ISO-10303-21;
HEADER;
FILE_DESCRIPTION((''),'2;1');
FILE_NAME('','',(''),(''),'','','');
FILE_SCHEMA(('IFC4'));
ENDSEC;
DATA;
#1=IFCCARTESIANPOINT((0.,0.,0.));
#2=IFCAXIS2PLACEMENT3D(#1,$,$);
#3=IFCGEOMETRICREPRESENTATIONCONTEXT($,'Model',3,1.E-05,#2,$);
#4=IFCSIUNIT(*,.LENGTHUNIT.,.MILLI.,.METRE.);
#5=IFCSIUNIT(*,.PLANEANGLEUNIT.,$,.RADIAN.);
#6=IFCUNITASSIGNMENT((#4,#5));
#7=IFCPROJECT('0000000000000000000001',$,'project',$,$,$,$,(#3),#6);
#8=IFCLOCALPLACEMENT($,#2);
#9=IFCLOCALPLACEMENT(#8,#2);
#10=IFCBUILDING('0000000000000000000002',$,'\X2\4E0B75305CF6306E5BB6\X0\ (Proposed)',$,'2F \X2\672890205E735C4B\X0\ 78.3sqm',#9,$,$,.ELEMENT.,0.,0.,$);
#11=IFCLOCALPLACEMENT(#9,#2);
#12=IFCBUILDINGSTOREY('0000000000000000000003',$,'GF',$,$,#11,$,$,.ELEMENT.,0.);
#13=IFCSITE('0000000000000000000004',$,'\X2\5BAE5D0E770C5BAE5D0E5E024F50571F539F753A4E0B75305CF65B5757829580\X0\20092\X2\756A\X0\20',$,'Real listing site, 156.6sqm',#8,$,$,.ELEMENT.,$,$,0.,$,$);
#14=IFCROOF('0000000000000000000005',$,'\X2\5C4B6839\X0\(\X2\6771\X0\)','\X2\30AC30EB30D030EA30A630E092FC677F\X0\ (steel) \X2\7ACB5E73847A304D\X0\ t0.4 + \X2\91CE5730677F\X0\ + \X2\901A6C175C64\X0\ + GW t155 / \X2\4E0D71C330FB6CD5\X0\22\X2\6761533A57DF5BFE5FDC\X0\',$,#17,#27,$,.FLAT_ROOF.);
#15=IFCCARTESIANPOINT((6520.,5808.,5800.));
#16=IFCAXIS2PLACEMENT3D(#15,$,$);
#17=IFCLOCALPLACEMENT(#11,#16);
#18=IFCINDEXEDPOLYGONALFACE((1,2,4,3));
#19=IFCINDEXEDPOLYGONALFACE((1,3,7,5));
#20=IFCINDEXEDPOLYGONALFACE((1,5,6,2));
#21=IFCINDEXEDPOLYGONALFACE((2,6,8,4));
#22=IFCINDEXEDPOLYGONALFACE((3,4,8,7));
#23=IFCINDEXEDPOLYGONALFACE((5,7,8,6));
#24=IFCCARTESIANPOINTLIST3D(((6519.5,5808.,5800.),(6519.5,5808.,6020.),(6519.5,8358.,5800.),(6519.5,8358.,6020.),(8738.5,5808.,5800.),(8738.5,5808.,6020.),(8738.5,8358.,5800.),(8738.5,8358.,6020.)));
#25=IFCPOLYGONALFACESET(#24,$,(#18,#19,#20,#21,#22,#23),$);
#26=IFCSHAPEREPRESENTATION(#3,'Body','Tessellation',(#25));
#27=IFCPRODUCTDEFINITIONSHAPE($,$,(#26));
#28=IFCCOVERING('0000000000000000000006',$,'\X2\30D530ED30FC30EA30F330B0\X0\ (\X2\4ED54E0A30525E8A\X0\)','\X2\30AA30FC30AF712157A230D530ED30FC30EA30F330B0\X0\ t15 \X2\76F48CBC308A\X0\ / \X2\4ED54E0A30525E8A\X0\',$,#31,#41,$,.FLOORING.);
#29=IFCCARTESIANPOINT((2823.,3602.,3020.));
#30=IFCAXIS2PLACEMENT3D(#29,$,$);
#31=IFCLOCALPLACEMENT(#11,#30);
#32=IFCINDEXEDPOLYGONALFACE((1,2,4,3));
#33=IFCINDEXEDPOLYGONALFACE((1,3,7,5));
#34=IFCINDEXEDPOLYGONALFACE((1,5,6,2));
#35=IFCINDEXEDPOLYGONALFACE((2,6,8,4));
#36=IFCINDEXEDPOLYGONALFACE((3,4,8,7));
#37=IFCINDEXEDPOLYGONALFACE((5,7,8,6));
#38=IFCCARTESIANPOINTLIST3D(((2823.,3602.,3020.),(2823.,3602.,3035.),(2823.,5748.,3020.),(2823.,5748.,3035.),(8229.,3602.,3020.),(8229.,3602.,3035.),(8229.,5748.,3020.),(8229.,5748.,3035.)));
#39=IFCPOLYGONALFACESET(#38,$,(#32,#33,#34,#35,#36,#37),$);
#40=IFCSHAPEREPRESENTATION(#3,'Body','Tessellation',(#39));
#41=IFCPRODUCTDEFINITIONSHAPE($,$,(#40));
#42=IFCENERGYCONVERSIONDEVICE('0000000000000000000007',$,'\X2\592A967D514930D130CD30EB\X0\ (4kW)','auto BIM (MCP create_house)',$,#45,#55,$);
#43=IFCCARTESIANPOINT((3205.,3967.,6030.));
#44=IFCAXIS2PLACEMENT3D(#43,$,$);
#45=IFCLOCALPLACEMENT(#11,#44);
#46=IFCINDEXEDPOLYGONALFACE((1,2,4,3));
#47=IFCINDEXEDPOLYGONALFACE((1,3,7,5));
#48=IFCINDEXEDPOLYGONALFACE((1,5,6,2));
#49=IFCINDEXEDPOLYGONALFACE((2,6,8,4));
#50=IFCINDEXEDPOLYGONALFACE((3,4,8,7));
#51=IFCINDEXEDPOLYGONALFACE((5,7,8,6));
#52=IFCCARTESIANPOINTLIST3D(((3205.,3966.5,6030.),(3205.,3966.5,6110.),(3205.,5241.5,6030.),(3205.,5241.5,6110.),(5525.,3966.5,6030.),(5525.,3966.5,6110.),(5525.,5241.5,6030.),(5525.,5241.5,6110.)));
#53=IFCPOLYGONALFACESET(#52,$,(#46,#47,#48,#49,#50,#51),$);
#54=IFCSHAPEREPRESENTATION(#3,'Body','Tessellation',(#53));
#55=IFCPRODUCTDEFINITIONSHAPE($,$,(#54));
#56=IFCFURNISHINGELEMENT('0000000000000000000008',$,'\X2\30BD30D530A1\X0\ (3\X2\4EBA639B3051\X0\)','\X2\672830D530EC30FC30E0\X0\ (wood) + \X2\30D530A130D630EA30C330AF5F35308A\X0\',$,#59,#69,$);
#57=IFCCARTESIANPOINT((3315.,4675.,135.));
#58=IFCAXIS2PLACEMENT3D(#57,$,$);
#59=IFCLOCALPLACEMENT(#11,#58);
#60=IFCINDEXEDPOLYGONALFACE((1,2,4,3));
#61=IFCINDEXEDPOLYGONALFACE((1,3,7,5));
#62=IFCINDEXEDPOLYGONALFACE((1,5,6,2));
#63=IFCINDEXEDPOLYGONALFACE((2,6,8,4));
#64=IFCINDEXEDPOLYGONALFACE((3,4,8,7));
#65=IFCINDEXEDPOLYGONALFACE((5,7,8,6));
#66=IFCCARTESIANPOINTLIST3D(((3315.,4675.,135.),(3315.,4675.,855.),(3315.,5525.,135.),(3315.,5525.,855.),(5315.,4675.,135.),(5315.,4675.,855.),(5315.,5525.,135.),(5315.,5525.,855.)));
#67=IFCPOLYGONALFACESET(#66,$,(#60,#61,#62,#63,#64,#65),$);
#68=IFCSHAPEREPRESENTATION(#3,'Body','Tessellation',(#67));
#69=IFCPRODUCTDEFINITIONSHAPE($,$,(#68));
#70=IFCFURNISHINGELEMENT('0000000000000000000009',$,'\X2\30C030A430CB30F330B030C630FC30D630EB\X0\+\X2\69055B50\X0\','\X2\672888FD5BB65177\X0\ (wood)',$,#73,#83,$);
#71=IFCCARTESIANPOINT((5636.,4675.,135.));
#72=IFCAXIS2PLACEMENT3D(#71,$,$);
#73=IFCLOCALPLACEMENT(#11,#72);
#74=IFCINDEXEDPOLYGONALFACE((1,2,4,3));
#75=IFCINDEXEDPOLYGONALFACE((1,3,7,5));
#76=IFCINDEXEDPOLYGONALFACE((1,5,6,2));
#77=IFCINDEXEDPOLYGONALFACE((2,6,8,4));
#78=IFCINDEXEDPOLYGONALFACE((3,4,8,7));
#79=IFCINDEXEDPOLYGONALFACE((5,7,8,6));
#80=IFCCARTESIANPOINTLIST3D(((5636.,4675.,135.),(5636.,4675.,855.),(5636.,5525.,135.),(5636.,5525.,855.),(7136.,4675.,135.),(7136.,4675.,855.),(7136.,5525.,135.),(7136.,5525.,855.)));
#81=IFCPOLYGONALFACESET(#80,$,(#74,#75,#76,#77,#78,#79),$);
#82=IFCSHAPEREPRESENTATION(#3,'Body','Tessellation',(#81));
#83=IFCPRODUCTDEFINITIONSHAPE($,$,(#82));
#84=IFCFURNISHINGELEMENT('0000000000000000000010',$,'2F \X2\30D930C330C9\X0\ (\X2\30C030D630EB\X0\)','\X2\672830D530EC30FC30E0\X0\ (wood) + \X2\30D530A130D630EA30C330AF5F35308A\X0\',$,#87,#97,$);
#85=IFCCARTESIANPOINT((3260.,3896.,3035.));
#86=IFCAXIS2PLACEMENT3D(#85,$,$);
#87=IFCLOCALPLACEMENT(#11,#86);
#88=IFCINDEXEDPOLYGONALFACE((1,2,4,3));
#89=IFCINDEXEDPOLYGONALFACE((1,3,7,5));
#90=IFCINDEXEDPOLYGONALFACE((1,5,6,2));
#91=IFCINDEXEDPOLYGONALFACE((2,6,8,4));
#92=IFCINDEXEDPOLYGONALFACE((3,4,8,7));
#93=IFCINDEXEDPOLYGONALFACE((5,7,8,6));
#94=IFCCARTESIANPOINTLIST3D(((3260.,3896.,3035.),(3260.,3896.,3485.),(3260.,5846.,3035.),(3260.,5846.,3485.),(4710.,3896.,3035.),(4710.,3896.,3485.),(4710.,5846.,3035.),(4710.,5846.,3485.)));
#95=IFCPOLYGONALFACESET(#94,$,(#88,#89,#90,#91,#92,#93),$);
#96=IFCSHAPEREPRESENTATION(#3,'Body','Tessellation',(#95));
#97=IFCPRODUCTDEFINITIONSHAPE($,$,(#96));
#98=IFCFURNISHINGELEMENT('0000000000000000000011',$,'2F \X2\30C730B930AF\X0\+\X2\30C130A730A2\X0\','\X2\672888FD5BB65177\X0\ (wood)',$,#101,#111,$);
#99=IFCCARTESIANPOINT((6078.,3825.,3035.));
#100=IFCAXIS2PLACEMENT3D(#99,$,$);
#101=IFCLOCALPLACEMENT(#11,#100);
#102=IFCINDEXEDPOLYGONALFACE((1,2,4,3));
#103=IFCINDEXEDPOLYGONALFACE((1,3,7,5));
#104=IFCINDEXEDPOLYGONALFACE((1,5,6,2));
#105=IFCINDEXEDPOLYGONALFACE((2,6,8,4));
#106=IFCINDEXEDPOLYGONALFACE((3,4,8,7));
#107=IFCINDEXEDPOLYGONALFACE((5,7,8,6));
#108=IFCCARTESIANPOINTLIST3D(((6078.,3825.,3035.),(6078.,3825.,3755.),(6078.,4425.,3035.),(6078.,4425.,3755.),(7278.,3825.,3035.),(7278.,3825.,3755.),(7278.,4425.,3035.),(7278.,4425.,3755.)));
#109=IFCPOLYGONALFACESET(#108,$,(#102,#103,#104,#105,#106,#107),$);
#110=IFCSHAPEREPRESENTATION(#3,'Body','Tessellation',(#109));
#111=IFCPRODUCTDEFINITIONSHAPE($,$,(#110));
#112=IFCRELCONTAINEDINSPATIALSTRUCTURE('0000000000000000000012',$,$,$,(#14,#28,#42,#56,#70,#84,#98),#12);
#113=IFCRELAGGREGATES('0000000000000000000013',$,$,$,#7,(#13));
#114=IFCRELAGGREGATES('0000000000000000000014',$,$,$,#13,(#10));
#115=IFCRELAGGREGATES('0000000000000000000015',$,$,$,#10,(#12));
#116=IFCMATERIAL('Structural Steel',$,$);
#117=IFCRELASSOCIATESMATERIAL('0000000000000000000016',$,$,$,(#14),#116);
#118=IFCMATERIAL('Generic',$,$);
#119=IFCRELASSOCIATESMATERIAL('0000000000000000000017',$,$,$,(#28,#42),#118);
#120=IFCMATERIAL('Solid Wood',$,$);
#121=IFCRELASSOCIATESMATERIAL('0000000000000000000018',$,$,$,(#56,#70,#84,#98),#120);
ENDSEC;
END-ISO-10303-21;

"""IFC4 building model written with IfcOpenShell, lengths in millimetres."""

from ifc_helpers import new_model, si_unit, frame, frame_2d, origin, place, context, project, spatial, rectangle, extrude, material, element, save


model = new_model("IFC4")

# Units and contexts
model_context = context("Model", 3, precision=1e-05, world=origin())
ifc_project = project(units=[si_unit("LENGTHUNIT", "METRE", prefix="MILLI"), si_unit("PLANEANGLEUNIT", "RADIAN")], contexts=[model_context])

# Site, building, storey
site_placement = place(None, origin())
site = spatial("IfcSite", under=ifc_project, at=site_placement, Name="宮崎県宮崎市佐土原町下田島字垂門20092番20", ObjectType="Real listing site, 156.6sqm", CompositionType="ELEMENT", RefElevation=0.0)
building_placement = place(site_placement, origin())
building = spatial("IfcBuilding", under=site, at=building_placement, Name="下田島の家 (Proposed)", ObjectType="2F 木造平屋 78.3sqm", CompositionType="ELEMENT", ElevationOfRefHeight=0.0, ElevationOfTerrain=0.0)
storey_placement = place(building_placement, origin())
storey = spatial("IfcBuildingStorey", under=building, at=storey_placement, Name="GF", CompositionType="ELEMENT", Elevation=0.0)

# Shared definitions
ifc_material_1 = material(Name="Solid Wood")

# Roof
ifc_material_2 = material(Name="Structural Steel")
roof_1_placement = place(storey_placement, frame((6520.0, 5808.0, 5800.0)))
element("IfcRoof", 1, at=roof_1_placement, inside=storey, material=ifc_material_2, Name="屋根(東)", Description="ガルバリウム鋼板 (steel) 立平葺き t0.4 + 野地板 + 通気層 + GW t155 / 不燃・法22条区域対応", PredefinedType="FLAT_ROOF", context=model_context, shape_type="SweptSolid", body=[
    extrude(rectangle(XDim=2219.0, YDim=2550.0, at=frame_2d((1109.0, 1275.0))), frame((6520.0, 5808.0, 5800.0)), (0.0, 0.0, 1.0), 220.0),
])

# Covering
ifc_material_3 = material(Name="Generic")
covering_placement = place(storey_placement, frame((2823.0, 3602.0, 3020.0)))
element("IfcCovering", 2, at=covering_placement, inside=storey, material=ifc_material_3, Name="フローリング (仕上げ床)", Description="オーク無垢フローリング t15 直貼り / 仕上げ床", PredefinedType="FLOORING", context=model_context, shape_type="SweptSolid", body=[
    extrude(rectangle(XDim=5406.0, YDim=2146.0, at=frame_2d((2703.0, 1073.0))), frame((2823.0, 3602.0, 3020.0)), (0.0, 0.0, 1.0), 15.0),
])

# Energy conversion device
energy_conversion_device_placement = place(storey_placement, frame((3205.0, 3967.0, 6030.0)))
element("IfcEnergyConversionDevice", 3, at=energy_conversion_device_placement, inside=storey, material=ifc_material_3, Name="太陽光パネル (4kW)", Description="auto BIM (MCP create_house)", context=model_context, shape_type="SweptSolid", body=[
    extrude(rectangle(XDim=2320.0, YDim=1275.0, at=frame_2d((1160.0, 637.0))), frame((3205.0, 3967.0, 6030.0)), (0.0, 0.0, 1.0), 80.0),
])

# Furnishing elements
furnishing_1_placement = place(storey_placement, frame((3315.0, 4675.0, 135.0)))
element("IfcFurnishingElement", 4, at=furnishing_1_placement, inside=storey, material=ifc_material_1, Name="ソファ (3人掛け)", Description="木フレーム (wood) + ファブリック張り", context=model_context, shape_type="SweptSolid", body=[
    extrude(rectangle(XDim=2000.0, YDim=850.0, at=frame_2d((1000.0, 425.0))), frame((3315.0, 4675.0, 135.0)), (0.0, 0.0, 1.0), 720.0),
])
furnishing_2_placement = place(storey_placement, frame((5636.0, 4675.0, 135.0)))
element("IfcFurnishingElement", 5, at=furnishing_2_placement, inside=storey, material=ifc_material_1, Name="ダイニングテーブル+椅子", Description="木製家具 (wood)", context=model_context, shape_type="SweptSolid", body=[
    extrude(rectangle(XDim=1500.0, YDim=850.0, at=frame_2d((750.0, 425.0))), frame((5636.0, 4675.0, 135.0)), (0.0, 0.0, 1.0), 720.0),
])
furnishing_3_placement = place(storey_placement, frame((3260.0, 3896.0, 3035.0)))
element("IfcFurnishingElement", 6, at=furnishing_3_placement, inside=storey, material=ifc_material_1, Name="2F ベッド (ダブル)", Description="木フレーム (wood) + ファブリック張り", context=model_context, shape_type="SweptSolid", body=[
    extrude(rectangle(XDim=1450.0, YDim=1950.0, at=frame_2d((725.0, 975.0))), frame((3260.0, 3896.0, 3035.0)), (0.0, 0.0, 1.0), 450.0),
])
furnishing_4_placement = place(storey_placement, frame((6078.0, 3825.0, 3035.0)))
element("IfcFurnishingElement", 7, at=furnishing_4_placement, inside=storey, material=ifc_material_1, Name="2F デスク+チェア", Description="木製家具 (wood)", context=model_context, shape_type="SweptSolid", body=[
    extrude(rectangle(XDim=1200.0, YDim=600.0, at=frame_2d((600.0, 300.0))), frame((6078.0, 3825.0, 3035.0)), (0.0, 0.0, 1.0), 720.0),
])

save(model, "model.ifc")
